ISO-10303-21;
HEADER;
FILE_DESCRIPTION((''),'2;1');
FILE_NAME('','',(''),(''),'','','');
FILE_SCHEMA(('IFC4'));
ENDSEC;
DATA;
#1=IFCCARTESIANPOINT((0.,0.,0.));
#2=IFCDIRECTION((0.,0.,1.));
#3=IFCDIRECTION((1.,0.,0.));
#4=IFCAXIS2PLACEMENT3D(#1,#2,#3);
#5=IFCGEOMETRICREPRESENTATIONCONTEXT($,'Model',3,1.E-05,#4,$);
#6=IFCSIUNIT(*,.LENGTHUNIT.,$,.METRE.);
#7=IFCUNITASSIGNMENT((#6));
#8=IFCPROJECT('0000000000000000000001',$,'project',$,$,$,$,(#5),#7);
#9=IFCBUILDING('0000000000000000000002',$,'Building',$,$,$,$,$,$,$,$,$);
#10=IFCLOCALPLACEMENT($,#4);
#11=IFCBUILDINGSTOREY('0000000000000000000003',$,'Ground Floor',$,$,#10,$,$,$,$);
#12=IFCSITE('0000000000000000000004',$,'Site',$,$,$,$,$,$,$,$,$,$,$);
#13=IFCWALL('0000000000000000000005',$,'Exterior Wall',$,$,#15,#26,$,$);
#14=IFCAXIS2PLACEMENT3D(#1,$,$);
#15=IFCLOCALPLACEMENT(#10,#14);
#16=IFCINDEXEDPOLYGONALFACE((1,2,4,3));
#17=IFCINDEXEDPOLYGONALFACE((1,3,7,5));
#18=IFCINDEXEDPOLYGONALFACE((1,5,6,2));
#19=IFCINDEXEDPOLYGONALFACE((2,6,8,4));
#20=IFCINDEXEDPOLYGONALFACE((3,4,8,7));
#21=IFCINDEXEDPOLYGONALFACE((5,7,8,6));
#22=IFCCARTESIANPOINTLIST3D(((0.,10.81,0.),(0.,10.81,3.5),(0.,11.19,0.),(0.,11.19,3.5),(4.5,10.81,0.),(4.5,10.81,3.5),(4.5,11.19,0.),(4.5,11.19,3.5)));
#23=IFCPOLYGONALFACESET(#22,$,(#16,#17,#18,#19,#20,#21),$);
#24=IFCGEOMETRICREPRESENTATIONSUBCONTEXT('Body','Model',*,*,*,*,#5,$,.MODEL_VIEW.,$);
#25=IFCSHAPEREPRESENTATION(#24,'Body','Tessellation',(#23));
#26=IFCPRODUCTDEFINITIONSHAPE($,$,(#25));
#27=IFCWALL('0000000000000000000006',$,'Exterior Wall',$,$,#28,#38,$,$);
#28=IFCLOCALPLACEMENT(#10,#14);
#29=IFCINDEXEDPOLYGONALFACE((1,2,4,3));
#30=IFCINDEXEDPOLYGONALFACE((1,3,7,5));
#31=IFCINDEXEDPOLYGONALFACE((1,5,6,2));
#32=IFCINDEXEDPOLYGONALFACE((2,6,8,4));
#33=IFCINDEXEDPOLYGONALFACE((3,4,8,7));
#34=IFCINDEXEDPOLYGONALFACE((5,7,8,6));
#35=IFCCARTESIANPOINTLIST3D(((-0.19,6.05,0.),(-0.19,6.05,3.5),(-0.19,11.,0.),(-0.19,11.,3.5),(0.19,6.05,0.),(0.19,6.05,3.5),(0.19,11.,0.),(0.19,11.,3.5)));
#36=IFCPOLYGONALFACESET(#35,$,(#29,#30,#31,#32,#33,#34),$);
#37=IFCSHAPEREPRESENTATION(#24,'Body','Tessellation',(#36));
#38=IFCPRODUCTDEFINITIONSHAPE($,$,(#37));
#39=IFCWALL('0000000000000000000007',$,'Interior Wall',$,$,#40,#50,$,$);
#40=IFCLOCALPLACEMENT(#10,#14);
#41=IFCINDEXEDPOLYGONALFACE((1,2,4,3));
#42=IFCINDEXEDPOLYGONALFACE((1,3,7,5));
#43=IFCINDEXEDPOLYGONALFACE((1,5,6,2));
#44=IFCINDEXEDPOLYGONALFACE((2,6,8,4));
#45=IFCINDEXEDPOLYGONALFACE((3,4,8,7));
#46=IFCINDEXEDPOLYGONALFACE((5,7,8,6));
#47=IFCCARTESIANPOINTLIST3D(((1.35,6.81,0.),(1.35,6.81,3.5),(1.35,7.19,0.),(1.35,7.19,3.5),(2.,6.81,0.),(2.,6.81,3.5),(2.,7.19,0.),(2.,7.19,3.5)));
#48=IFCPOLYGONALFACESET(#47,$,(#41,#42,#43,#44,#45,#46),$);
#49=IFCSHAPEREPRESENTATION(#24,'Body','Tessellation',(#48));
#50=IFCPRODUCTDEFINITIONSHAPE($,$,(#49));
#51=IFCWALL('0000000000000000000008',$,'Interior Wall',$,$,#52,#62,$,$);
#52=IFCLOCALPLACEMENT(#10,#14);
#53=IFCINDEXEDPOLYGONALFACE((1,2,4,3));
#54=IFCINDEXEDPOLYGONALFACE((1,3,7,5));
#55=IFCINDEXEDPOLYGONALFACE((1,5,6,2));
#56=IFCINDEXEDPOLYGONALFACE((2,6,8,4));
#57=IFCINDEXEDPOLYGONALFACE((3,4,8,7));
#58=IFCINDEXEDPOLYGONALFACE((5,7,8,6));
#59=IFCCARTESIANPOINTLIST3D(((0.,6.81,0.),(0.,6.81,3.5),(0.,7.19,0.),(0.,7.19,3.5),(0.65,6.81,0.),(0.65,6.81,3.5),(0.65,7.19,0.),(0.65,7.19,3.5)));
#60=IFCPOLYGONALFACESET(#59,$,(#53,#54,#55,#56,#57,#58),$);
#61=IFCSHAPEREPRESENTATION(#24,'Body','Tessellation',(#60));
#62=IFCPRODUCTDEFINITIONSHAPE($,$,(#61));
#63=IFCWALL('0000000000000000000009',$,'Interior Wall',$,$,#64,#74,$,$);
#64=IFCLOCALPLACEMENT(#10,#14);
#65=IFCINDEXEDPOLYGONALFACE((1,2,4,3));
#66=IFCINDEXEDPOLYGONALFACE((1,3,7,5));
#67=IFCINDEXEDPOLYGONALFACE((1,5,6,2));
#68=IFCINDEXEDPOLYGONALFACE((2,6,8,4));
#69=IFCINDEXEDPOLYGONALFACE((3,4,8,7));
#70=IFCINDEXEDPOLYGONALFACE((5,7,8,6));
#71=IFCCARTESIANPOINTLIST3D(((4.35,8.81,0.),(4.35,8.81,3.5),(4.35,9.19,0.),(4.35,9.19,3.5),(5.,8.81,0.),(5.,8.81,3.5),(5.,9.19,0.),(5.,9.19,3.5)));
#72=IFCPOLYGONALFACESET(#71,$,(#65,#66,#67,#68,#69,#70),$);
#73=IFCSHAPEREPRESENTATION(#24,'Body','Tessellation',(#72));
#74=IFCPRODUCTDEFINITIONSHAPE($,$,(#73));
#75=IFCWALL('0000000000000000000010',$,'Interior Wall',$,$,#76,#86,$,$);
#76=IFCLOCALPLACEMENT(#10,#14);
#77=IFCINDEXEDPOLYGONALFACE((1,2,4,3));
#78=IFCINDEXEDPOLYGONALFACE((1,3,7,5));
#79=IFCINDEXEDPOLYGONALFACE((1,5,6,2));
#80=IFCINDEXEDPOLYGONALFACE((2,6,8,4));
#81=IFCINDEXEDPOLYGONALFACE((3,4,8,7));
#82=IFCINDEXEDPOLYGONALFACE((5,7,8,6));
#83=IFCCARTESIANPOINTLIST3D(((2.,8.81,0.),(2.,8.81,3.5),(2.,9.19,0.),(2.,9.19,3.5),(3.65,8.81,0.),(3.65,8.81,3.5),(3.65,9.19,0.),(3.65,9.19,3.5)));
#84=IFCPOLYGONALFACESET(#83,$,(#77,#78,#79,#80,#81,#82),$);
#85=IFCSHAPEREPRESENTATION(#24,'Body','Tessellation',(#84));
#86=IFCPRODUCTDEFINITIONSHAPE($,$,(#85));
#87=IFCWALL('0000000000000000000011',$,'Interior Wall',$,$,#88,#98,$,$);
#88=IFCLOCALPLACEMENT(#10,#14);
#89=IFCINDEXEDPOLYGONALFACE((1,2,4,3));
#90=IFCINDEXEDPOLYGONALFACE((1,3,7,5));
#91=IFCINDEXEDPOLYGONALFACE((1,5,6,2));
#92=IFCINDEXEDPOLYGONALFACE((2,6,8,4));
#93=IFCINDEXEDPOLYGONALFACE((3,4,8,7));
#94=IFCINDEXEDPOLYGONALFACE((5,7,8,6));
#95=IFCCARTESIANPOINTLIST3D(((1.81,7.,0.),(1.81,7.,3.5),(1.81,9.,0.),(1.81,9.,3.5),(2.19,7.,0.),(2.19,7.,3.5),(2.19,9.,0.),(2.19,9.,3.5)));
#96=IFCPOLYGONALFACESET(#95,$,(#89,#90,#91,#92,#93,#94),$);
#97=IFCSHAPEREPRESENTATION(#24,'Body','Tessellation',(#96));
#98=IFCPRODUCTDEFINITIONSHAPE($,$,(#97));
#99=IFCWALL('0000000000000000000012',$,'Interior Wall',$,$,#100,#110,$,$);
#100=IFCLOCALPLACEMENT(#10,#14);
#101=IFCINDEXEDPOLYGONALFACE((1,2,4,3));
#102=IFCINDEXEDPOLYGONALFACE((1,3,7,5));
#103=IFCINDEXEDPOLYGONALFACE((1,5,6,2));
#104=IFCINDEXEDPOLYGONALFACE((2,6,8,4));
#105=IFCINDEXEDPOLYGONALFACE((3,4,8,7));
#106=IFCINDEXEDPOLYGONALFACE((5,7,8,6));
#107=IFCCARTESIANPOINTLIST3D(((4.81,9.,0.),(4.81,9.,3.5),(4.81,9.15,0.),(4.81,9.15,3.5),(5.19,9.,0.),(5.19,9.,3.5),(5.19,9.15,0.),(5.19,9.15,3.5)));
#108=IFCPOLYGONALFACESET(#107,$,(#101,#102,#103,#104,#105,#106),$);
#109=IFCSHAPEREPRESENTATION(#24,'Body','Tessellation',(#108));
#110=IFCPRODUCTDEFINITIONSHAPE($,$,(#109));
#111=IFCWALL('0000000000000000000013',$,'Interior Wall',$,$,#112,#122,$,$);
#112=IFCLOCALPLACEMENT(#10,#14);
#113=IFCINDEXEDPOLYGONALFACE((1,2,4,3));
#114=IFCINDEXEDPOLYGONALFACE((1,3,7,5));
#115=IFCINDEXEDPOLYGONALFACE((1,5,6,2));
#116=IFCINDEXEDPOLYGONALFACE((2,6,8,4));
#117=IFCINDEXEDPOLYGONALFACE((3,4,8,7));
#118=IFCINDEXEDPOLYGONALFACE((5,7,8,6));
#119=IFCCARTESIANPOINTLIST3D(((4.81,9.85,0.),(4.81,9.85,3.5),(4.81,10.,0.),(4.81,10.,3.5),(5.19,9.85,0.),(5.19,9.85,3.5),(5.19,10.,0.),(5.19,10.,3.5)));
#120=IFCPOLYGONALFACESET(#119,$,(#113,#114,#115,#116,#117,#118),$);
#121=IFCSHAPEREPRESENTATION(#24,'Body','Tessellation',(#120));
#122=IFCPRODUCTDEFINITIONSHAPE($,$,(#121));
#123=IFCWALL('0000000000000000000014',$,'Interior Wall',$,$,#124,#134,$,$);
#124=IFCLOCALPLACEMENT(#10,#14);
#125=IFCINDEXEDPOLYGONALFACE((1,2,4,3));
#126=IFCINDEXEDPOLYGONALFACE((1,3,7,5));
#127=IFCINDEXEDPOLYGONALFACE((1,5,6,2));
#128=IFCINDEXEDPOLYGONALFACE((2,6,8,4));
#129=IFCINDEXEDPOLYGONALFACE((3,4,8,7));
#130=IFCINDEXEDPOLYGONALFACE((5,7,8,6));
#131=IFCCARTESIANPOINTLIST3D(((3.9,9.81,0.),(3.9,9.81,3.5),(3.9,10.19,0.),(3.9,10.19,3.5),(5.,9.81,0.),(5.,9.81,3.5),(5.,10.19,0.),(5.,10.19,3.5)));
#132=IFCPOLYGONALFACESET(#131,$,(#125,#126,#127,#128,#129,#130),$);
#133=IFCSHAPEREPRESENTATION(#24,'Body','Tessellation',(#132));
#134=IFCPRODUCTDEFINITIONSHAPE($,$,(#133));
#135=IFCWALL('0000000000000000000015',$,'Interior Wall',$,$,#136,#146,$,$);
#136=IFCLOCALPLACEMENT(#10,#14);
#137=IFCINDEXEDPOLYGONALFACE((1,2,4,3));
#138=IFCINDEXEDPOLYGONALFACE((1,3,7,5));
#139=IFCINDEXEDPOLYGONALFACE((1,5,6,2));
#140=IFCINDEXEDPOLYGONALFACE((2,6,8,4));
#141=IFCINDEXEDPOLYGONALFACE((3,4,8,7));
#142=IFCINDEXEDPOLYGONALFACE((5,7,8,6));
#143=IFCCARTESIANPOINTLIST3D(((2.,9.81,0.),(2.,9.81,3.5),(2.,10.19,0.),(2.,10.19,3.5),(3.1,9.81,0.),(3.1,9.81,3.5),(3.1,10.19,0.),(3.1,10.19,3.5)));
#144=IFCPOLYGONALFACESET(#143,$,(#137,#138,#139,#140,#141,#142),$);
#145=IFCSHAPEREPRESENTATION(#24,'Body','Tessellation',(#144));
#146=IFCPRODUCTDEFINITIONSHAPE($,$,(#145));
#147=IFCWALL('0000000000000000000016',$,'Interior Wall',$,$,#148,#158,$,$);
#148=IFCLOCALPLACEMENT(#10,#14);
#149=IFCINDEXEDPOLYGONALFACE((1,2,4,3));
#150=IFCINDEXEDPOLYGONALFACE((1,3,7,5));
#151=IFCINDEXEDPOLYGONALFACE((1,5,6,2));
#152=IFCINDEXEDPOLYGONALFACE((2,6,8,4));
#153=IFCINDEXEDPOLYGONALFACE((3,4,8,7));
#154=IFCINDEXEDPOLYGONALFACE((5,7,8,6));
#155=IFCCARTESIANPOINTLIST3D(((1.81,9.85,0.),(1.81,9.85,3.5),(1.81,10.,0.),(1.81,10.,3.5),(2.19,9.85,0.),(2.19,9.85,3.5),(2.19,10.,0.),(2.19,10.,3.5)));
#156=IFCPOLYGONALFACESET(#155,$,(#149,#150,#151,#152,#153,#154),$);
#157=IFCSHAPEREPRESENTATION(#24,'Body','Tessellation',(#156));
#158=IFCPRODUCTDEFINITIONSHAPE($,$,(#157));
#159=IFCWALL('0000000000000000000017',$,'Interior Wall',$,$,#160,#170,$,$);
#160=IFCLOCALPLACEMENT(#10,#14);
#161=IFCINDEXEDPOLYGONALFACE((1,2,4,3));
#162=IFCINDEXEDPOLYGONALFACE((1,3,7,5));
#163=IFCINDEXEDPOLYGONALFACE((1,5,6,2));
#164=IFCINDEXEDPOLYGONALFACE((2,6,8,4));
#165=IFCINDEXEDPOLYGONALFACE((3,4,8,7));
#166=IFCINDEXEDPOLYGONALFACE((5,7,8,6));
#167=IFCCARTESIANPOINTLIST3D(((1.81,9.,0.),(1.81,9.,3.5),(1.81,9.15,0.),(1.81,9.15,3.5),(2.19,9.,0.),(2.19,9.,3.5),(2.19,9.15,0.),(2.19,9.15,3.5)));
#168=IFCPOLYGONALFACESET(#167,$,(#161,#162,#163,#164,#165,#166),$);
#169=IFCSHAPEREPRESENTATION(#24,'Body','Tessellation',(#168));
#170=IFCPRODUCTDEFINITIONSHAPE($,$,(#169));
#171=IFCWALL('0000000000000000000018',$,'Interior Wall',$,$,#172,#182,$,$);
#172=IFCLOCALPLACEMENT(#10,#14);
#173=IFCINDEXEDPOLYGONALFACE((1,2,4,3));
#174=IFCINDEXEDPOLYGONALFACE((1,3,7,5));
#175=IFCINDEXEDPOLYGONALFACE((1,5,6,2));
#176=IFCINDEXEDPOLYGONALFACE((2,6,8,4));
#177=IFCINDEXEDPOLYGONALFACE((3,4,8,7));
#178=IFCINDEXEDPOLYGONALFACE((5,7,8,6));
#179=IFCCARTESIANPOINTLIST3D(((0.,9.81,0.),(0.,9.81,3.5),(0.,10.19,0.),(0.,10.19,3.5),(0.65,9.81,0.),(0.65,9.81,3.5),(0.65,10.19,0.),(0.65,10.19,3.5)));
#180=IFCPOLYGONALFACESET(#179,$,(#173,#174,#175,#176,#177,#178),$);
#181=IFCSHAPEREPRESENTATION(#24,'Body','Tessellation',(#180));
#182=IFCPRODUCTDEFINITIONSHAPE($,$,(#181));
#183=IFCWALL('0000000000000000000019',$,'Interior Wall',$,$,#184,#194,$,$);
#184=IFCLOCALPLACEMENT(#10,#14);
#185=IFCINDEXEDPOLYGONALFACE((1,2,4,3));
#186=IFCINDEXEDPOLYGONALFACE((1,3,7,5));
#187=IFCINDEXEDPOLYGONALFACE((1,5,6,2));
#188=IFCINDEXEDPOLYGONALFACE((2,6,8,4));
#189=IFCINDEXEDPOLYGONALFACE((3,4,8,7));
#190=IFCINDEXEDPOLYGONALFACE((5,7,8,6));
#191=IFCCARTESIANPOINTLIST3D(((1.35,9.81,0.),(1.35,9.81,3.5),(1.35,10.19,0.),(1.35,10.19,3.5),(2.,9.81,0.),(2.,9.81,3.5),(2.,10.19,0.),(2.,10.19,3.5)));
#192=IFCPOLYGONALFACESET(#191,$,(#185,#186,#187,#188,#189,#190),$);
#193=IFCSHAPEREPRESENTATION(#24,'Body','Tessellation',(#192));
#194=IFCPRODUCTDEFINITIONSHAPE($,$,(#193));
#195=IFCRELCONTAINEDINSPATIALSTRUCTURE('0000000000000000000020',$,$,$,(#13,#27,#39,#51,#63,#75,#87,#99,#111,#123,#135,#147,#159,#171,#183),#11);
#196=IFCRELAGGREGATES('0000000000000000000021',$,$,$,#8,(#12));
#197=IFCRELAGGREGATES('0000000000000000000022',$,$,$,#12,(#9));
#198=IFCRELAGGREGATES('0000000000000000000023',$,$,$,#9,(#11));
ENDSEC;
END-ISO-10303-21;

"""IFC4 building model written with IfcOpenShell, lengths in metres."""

from ifc_helpers import new_model, si_unit, frame, origin_with_axes, place, context, subcontext, project, spatial, indexed_curve, outline, extrude, element, save


model = new_model("IFC4")

# Units and contexts
model_context = context("Model", 3, precision=1e-05, world=origin_with_axes())
body_context = subcontext(model_context, "Body", "Model", "MODEL_VIEW")
ifc_project = project(units=[si_unit("LENGTHUNIT", "METRE")], contexts=[model_context])

# Site, building, storey
site = spatial("IfcSite", under=ifc_project, Name="Site")
building = spatial("IfcBuilding", under=site, Name="Building")
storey_placement = place(None, origin_with_axes())
storey = spatial("IfcBuildingStorey", under=building, at=storey_placement, Name="Ground Floor")

# Walls
wall_1_placement = place(storey_placement, frame((4.5, 11.0, 0.0), z_axis=(0.0, 0.0, 1.0), x_axis=(-1.0, 0.0, 0.0)))
element("IfcWall", 1, at=wall_1_placement, inside=storey, Name="Exterior Wall", context=body_context, shape_type="SweptSolid", body=[
    extrude(outline(indexed_curve([(0.0, 0.0), (0.0, 0.38), (4.5, 0.38), (4.5, 0.0), (0.0, 0.0)], self_intersect=False)), frame((0.0, -0.19, 0.0), z_axis=(0.0, 0.0, 1.0), x_axis=(1.0, 0.0, 0.0)), (0.0, 0.0, 1.0), 3.5),
])
wall_2_placement = place(storey_placement, frame((0.0, 11.0, 0.0), z_axis=(0.0, 0.0, 1.0), x_axis=(0.0, -1.0, 0.0)))
element("IfcWall", 2, at=wall_2_placement, inside=storey, Name="Exterior Wall", context=body_context, shape_type="SweptSolid", body=[
    extrude(outline(indexed_curve([(0.0, 0.0), (0.0, 0.38), (4.95, 0.38), (4.95, 0.0), (0.0, 0.0)], self_intersect=False)), frame((0.0, -0.19, 0.0), z_axis=(0.0, 0.0, 1.0), x_axis=(1.0, 0.0, 0.0)), (0.0, 0.0, 1.0), 3.5),
])
for number, where, z_axis, x_axis, name in (
    (3, (2.0, 7.0, 0.0), (0.0, 0.0, 1.0), (-1.0, 0.0, 0.0), "Interior Wall"),
    (4, (0.65, 7.0, 0.0), (0.0, 0.0, 1.0), (-1.0, 0.0, 0.0), "Interior Wall"),
):
    element("IfcWall", number, at=place(storey_placement, frame(where, z_axis=z_axis, x_axis=x_axis)), inside=storey, Name=name, context=body_context, shape_type="SweptSolid", body=[
        extrude(outline(indexed_curve([(0.0, 0.0), (0.0, 0.38), (0.65, 0.38), (0.65, 0.0), (0.0, 0.0)], self_intersect=False)), frame((0.0, -0.19, 0.0), z_axis=(0.0, 0.0, 1.0), x_axis=(1.0, 0.0, 0.0)), (0.0, 0.0, 1.0), 3.5),
    ])
wall_3_placement = place(storey_placement, frame((5.0, 9.0, 0.0), z_axis=(0.0, 0.0, 1.0), x_axis=(-1.0, 0.0, 0.0)))
element("IfcWall", 5, at=wall_3_placement, inside=storey, Name="Interior Wall", context=body_context, shape_type="SweptSolid", body=[
    extrude(outline(indexed_curve([(0.0, 0.0), (0.0, 0.38), (0.65, 0.38), (0.65, 0.0), (0.0, 0.0)], self_intersect=False)), frame((0.0, -0.19, 0.0), z_axis=(0.0, 0.0, 1.0), x_axis=(1.0, 0.0, 0.0)), (0.0, 0.0, 1.0), 3.5),
])
wall_4_placement = place(storey_placement, frame((3.65, 9.0, 0.0), z_axis=(0.0, 0.0, 1.0), x_axis=(-1.0, 0.0, 0.0)))
element("IfcWall", 6, at=wall_4_placement, inside=storey, Name="Interior Wall", context=body_context, shape_type="SweptSolid", body=[
    extrude(outline(indexed_curve([(0.0, 0.0), (0.0, 0.38), (1.65, 0.38), (1.65, 0.0), (0.0, 0.0)], self_intersect=False)), frame((0.0, -0.19, 0.0), z_axis=(0.0, 0.0, 1.0), x_axis=(1.0, 0.0, 0.0)), (0.0, 0.0, 1.0), 3.5),
])
wall_5_placement = place(storey_placement, frame((2.0, 9.0, 0.0), z_axis=(0.0, 0.0, 1.0), x_axis=(0.0, -1.0, 0.0)))
element("IfcWall", 7, at=wall_5_placement, inside=storey, Name="Interior Wall", context=body_context, shape_type="SweptSolid", body=[
    extrude(outline(indexed_curve([(0.0, 0.0), (0.0, 0.38), (2.0, 0.38), (2.0, 0.0), (0.0, 0.0)], self_intersect=False)), frame((0.0, -0.19, 0.0), z_axis=(0.0, 0.0, 1.0), x_axis=(1.0, 0.0, 0.0)), (0.0, 0.0, 1.0), 3.5),
])
for number, where, z_axis, x_axis, name in (
    (8, (5.0, 9.0, 0.0), (0.0, 0.0, 1.0), (0.0, 1.0, 0.0), "Interior Wall"),
    (9, (5.0, 9.85, 0.0), (0.0, 0.0, 1.0), (0.0, 1.0, 0.0), "Interior Wall"),
):
    element("IfcWall", number, at=place(storey_placement, frame(where, z_axis=z_axis, x_axis=x_axis)), inside=storey, Name=name, context=body_context, shape_type="SweptSolid", body=[
        extrude(outline(indexed_curve([(0.0, 0.0), (0.0, 0.38), (0.15, 0.38), (0.15, 0.0), (0.0, 0.0)], self_intersect=False)), frame((0.0, -0.19, 0.0), z_axis=(0.0, 0.0, 1.0), x_axis=(1.0, 0.0, 0.0)), (0.0, 0.0, 1.0), 3.5),
    ])
for number, where, z_axis, x_axis, name in (
    (10, (5.0, 10.0, 0.0), (0.0, 0.0, 1.0), (-1.0, 0.0, 0.0), "Interior Wall"),
    (11, (3.1, 10.0, 0.0), (0.0, 0.0, 1.0), (-1.0, 0.0, 0.0), "Interior Wall"),
):
    element("IfcWall", number, at=place(storey_placement, frame(where, z_axis=z_axis, x_axis=x_axis)), inside=storey, Name=name, context=body_context, shape_type="SweptSolid", body=[
        extrude(outline(indexed_curve([(0.0, 0.0), (0.0, 0.38), (1.1, 0.38), (1.1, 0.0), (0.0, 0.0)], self_intersect=False)), frame((0.0, -0.19, 0.0), z_axis=(0.0, 0.0, 1.0), x_axis=(1.0, 0.0, 0.0)), (0.0, 0.0, 1.0), 3.5),
    ])
for number, where, z_axis, x_axis, name in (
    (12, (2.0, 10.0, 0.0), (0.0, 0.0, 1.0), (0.0, -1.0, 0.0), "Interior Wall"),
    (13, (2.0, 9.15, 0.0), (0.0, 0.0, 1.0), (0.0, -1.0, 0.0), "Interior Wall"),
):
    element("IfcWall", number, at=place(storey_placement, frame(where, z_axis=z_axis, x_axis=x_axis)), inside=storey, Name=name, context=body_context, shape_type="SweptSolid", body=[
        extrude(outline(indexed_curve([(0.0, 0.0), (0.0, 0.38), (0.15, 0.38), (0.15, 0.0), (0.0, 0.0)], self_intersect=False)), frame((0.0, -0.19, 0.0), z_axis=(0.0, 0.0, 1.0), x_axis=(1.0, 0.0, 0.0)), (0.0, 0.0, 1.0), 3.5),
    ])
wall_6_placement = place(storey_placement, frame((0.0, 10.0, 0.0), z_axis=(0.0, 0.0, 1.0), x_axis=(1.0, 0.0, 0.0)))
element("IfcWall", 14, at=wall_6_placement, inside=storey, Name="Interior Wall", context=body_context, shape_type="SweptSolid", body=[
    extrude(outline(indexed_curve([(0.0, 0.0), (0.0, 0.38), (0.65, 0.38), (0.65, 0.0), (0.0, 0.0)], self_intersect=False)), frame((0.0, -0.19, 0.0), z_axis=(0.0, 0.0, 1.0), x_axis=(1.0, 0.0, 0.0)), (0.0, 0.0, 1.0), 3.5),
])
wall_7_placement = place(storey_placement, frame((1.35, 10.0, 0.0), z_axis=(0.0, 0.0, 1.0), x_axis=(1.0, 0.0, 0.0)))
element("IfcWall", 15, at=wall_7_placement, inside=storey, Name="Interior Wall", context=body_context, shape_type="SweptSolid", body=[
    extrude(outline(indexed_curve([(0.0, 0.0), (0.0, 0.38), (0.65, 0.38), (0.65, 0.0), (0.0, 0.0)], self_intersect=False)), frame((0.0, -0.19, 0.0), z_axis=(0.0, 0.0, 1.0), x_axis=(1.0, 0.0, 0.0)), (0.0, 0.0, 1.0), 3.5),
])

save(model, "model.ifc")
